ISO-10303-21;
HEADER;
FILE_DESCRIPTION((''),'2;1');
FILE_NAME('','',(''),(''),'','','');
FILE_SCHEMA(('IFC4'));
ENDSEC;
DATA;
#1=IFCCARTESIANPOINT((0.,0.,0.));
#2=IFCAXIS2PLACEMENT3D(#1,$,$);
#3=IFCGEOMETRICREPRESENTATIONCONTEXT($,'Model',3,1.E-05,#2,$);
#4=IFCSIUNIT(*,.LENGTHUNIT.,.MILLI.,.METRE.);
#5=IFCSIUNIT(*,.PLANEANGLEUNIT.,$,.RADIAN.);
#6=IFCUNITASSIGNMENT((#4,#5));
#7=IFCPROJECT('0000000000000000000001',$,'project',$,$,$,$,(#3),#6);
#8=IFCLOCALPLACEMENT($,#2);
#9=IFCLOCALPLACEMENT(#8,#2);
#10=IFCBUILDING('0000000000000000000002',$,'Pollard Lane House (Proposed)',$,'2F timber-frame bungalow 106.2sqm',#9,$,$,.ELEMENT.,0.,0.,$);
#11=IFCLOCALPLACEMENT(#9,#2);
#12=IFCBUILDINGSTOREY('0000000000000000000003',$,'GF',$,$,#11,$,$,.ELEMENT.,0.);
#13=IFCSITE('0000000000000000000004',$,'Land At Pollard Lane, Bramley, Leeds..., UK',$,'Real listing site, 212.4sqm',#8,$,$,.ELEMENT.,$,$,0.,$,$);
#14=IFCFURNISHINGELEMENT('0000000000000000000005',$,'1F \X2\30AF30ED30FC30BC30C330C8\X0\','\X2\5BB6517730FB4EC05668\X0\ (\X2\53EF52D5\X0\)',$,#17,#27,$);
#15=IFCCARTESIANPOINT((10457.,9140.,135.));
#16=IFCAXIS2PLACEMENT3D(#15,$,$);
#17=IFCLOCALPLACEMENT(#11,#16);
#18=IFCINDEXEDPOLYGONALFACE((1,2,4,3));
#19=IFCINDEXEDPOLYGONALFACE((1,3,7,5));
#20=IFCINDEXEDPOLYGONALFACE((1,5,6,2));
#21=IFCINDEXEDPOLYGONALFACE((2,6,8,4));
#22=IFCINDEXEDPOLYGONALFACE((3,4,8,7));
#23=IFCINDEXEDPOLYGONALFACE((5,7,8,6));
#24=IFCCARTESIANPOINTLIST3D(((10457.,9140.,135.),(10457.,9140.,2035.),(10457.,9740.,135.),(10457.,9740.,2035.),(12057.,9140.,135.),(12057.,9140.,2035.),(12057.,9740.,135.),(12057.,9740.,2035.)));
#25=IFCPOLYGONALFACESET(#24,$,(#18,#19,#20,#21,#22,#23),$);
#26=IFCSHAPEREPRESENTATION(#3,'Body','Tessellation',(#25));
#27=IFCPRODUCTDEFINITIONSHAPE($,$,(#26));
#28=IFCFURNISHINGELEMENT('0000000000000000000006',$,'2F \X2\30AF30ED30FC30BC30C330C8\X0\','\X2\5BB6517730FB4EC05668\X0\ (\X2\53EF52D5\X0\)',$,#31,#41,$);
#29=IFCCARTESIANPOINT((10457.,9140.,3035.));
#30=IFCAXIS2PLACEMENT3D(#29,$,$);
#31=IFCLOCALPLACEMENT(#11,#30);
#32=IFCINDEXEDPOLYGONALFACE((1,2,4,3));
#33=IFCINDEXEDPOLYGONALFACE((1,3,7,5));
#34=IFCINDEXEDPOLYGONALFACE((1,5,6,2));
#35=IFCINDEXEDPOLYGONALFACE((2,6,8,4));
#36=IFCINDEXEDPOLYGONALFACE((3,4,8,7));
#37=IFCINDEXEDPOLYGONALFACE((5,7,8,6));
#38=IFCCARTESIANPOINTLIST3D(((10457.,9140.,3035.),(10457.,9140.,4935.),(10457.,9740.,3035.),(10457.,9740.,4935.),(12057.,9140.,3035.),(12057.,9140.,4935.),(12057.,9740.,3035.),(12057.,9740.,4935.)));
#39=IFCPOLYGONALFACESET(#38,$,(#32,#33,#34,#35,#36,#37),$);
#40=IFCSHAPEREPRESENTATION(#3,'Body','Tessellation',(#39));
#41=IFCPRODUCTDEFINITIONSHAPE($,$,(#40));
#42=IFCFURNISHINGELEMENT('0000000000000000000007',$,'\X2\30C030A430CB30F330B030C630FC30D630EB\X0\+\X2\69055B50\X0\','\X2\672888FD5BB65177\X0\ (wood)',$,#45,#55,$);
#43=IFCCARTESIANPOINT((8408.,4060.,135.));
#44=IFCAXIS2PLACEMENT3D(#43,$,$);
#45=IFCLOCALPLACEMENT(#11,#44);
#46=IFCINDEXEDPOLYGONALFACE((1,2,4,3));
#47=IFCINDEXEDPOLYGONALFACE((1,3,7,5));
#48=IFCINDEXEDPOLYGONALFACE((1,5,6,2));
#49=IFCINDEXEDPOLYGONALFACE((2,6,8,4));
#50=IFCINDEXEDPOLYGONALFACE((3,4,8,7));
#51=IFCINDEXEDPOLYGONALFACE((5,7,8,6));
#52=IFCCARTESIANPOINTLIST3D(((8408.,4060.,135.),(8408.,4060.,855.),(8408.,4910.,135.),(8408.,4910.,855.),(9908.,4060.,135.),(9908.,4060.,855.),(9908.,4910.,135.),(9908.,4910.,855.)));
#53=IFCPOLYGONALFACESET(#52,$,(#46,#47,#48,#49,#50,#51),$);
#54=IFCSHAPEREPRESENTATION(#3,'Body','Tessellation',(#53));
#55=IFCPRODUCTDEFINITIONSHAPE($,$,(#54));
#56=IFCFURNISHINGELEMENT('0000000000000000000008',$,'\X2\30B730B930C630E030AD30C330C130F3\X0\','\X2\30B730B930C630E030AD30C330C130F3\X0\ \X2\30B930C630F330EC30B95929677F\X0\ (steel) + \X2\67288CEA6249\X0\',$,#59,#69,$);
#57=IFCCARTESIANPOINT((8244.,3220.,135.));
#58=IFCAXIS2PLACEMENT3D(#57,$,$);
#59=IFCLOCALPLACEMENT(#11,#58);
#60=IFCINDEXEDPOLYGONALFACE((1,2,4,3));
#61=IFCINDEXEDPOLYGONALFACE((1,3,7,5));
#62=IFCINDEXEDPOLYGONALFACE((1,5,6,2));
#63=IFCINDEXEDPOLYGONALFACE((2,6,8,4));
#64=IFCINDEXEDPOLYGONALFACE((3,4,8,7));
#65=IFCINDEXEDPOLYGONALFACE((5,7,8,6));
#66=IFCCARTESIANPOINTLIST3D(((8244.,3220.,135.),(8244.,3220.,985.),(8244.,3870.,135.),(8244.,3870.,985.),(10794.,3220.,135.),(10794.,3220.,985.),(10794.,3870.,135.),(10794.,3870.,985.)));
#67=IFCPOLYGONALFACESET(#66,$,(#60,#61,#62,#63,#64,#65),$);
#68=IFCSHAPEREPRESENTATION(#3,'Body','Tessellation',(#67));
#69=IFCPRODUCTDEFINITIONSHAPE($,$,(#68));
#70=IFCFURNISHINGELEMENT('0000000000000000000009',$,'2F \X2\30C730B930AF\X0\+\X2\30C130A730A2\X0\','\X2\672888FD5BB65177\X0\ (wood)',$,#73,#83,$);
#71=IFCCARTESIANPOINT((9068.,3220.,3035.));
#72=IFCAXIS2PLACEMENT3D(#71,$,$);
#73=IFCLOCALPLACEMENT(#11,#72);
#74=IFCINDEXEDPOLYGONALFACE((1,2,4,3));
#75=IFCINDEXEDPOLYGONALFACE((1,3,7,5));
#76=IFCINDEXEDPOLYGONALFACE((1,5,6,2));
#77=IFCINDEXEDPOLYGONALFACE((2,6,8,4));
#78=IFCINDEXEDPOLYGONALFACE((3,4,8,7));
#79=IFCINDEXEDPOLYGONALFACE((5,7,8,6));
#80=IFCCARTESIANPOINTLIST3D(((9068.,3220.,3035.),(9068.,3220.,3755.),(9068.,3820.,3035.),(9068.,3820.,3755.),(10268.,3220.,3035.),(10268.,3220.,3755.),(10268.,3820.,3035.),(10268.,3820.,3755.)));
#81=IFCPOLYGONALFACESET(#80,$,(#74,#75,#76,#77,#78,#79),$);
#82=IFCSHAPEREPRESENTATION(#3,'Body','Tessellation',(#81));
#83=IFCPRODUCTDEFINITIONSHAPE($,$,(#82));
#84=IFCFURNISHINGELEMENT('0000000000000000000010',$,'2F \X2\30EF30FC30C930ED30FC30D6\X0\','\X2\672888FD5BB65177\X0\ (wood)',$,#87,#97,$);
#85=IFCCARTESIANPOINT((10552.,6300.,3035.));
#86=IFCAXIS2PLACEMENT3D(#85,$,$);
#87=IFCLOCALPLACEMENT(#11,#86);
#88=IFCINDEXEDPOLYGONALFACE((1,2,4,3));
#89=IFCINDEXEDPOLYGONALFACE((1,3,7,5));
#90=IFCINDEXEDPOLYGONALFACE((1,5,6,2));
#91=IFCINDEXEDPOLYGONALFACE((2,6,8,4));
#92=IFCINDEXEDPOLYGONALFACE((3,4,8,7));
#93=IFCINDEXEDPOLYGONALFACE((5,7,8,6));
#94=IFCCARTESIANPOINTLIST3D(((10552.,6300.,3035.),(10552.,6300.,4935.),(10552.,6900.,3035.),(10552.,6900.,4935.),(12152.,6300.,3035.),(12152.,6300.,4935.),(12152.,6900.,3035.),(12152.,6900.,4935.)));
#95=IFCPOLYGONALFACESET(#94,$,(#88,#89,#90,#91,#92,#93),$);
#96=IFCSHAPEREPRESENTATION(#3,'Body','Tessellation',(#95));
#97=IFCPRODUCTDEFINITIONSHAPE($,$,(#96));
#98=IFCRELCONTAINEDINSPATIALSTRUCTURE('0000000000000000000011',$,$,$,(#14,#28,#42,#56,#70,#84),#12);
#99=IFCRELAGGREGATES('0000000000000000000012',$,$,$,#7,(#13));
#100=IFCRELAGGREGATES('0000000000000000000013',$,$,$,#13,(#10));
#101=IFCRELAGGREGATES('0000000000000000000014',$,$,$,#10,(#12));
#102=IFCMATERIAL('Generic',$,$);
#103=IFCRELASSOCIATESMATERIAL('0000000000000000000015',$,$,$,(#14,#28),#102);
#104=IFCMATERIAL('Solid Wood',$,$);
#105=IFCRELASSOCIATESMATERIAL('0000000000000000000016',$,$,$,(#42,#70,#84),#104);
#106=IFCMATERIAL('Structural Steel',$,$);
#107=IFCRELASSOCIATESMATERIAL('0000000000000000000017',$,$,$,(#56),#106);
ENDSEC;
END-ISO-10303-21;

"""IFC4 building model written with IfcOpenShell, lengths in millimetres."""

from ifc_helpers import new_model, si_unit, frame, frame_2d, origin, place, context, project, spatial, rectangle, extrude, material, element, save


model = new_model("IFC4")

# Units and contexts
model_context = context("Model", 3, precision=1e-05, world=origin())
ifc_project = project(units=[si_unit("LENGTHUNIT", "METRE", prefix="MILLI"), si_unit("PLANEANGLEUNIT", "RADIAN")], contexts=[model_context])

# Site, building, storey
site_placement = place(None, origin())
site = spatial("IfcSite", under=ifc_project, at=site_placement, Name="Land At Pollard Lane, Bramley, Leeds..., UK", ObjectType="Real listing site, 212.4sqm", CompositionType="ELEMENT", RefElevation=0.0)
building_placement = place(site_placement, origin())
building = spatial("IfcBuilding", under=site, at=building_placement, Name="Pollard Lane House (Proposed)", ObjectType="2F timber-frame bungalow 106.2sqm", CompositionType="ELEMENT", ElevationOfRefHeight=0.0, ElevationOfTerrain=0.0)
storey_placement = place(building_placement, origin())
storey = spatial("IfcBuildingStorey", under=building, at=storey_placement, Name="GF", CompositionType="ELEMENT", Elevation=0.0)

# Shared definitions
ifc_material_1 = material(Name="Solid Wood")

# Shared definitions
ifc_material_2 = material(Name="Generic")

# Furnishing elements
furnishing_1_placement = place(storey_placement, frame((10457.0, 9140.0, 135.0)))
element("IfcFurnishingElement", 1, at=furnishing_1_placement, inside=storey, material=ifc_material_2, Name="1F クローゼット", Description="家具・什器 (可動)", context=model_context, shape_type="SweptSolid", body=[
    extrude(rectangle(XDim=1600.0, YDim=600.0, at=frame_2d((800.0, 300.0))), frame((10457.0, 9140.0, 135.0)), (0.0, 0.0, 1.0), 1900.0),
])
furnishing_2_placement = place(storey_placement, frame((10457.0, 9140.0, 3035.0)))
element("IfcFurnishingElement", 2, at=furnishing_2_placement, inside=storey, material=ifc_material_2, Name="2F クローゼット", Description="家具・什器 (可動)", context=model_context, shape_type="SweptSolid", body=[
    extrude(rectangle(XDim=1600.0, YDim=600.0, at=frame_2d((800.0, 300.0))), frame((10457.0, 9140.0, 3035.0)), (0.0, 0.0, 1.0), 1900.0),
])
furnishing_3_placement = place(storey_placement, frame((8408.0, 4060.0, 135.0)))
element("IfcFurnishingElement", 3, at=furnishing_3_placement, inside=storey, material=ifc_material_1, Name="ダイニングテーブル+椅子", Description="木製家具 (wood)", context=model_context, shape_type="SweptSolid", body=[
    extrude(rectangle(XDim=1500.0, YDim=850.0, at=frame_2d((750.0, 425.0))), frame((8408.0, 4060.0, 135.0)), (0.0, 0.0, 1.0), 720.0),
])
ifc_material_3 = material(Name="Structural Steel")
furnishing_4_placement = place(storey_placement, frame((8244.0, 3220.0, 135.0)))
element("IfcFurnishingElement", 4, at=furnishing_4_placement, inside=storey, material=ifc_material_3, Name="システムキッチン", Description="システムキッチン ステンレス天板 (steel) + 木質扉", context=model_context, shape_type="SweptSolid", body=[
    extrude(rectangle(XDim=2550.0, YDim=650.0, at=frame_2d((1275.0, 325.0))), frame((8244.0, 3220.0, 135.0)), (0.0, 0.0, 1.0), 850.0),
])
furnishing_5_placement = place(storey_placement, frame((9068.0, 3220.0, 3035.0)))
element("IfcFurnishingElement", 5, at=furnishing_5_placement, inside=storey, material=ifc_material_1, Name="2F デスク+チェア", Description="木製家具 (wood)", context=model_context, shape_type="SweptSolid", body=[
    extrude(rectangle(XDim=1200.0, YDim=600.0, at=frame_2d((600.0, 300.0))), frame((9068.0, 3220.0, 3035.0)), (0.0, 0.0, 1.0), 720.0),
])
furnishing_6_placement = place(storey_placement, frame((10552.0, 6300.0, 3035.0)))
element("IfcFurnishingElement", 6, at=furnishing_6_placement, inside=storey, material=ifc_material_1, Name="2F ワードローブ", Description="木製家具 (wood)", context=model_context, shape_type="SweptSolid", body=[
    extrude(rectangle(XDim=1600.0, YDim=600.0, at=frame_2d((800.0, 300.0))), frame((10552.0, 6300.0, 3035.0)), (0.0, 0.0, 1.0), 1900.0),
])

save(model, "model.ifc")
